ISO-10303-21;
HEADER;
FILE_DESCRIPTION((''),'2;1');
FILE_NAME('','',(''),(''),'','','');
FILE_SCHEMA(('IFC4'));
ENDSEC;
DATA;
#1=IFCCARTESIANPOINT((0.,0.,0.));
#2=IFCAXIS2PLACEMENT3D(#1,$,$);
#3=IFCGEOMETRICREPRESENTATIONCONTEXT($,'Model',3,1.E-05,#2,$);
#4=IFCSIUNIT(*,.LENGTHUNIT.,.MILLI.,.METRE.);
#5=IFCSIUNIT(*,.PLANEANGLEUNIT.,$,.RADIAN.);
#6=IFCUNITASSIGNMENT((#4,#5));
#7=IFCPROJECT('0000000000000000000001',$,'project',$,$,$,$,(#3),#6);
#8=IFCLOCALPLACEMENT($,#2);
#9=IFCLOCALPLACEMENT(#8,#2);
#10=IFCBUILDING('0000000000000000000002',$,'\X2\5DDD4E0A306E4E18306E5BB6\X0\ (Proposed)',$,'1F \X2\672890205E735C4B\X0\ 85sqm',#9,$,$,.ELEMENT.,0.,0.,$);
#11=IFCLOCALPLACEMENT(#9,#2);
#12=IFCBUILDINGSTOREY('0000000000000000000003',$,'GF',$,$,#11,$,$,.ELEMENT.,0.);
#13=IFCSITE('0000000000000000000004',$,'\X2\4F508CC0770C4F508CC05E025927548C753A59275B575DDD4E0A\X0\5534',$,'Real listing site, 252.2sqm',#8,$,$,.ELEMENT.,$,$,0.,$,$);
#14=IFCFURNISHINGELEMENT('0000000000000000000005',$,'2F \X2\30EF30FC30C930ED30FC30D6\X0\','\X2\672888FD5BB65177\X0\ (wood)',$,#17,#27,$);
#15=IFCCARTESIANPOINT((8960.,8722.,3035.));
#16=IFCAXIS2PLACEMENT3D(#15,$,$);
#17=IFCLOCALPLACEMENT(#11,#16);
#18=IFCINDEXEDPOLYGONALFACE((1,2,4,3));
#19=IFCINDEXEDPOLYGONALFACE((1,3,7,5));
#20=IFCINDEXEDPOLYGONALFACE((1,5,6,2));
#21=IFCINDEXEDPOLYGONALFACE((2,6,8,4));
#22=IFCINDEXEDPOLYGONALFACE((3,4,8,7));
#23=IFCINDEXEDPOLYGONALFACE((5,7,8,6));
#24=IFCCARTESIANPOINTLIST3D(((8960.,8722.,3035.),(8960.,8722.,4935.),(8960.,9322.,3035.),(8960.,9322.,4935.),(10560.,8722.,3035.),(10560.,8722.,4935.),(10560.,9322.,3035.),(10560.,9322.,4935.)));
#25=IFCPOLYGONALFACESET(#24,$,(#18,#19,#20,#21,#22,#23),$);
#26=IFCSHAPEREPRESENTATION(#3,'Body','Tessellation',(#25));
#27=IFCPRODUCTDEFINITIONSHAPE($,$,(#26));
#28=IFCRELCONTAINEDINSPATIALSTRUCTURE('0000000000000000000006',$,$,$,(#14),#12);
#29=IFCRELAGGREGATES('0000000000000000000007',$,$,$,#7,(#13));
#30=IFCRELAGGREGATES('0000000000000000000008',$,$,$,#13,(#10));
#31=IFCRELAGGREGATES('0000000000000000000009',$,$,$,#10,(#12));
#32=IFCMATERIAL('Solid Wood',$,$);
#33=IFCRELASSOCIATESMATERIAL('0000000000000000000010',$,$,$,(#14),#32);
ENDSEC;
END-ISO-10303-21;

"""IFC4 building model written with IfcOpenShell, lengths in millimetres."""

from ifc_helpers import new_model, si_unit, frame, frame_2d, origin, place, context, project, spatial, rectangle, extrude, material, element, save


model = new_model("IFC4")

# Units and contexts
model_context = context("Model", 3, precision=1e-05, world=origin())
ifc_project = project(units=[si_unit("LENGTHUNIT", "METRE", prefix="MILLI"), si_unit("PLANEANGLEUNIT", "RADIAN")], contexts=[model_context])

# Site, building, storey
site_placement = place(None, origin())
site = spatial("IfcSite", under=ifc_project, at=site_placement, Name="佐賀県佐賀市大和町大字川上5534", ObjectType="Real listing site, 252.2sqm", CompositionType="ELEMENT", RefElevation=0.0)
building_placement = place(site_placement, origin())
building = spatial("IfcBuilding", under=site, at=building_placement, Name="川上の丘の家 (Proposed)", ObjectType="1F 木造平屋 85sqm", CompositionType="ELEMENT", ElevationOfRefHeight=0.0, ElevationOfTerrain=0.0)
storey_placement = place(building_placement, origin())
storey = spatial("IfcBuildingStorey", under=building, at=storey_placement, Name="GF", CompositionType="ELEMENT", Elevation=0.0)

# Shared definitions
ifc_material_1 = material(Name="Solid Wood")

# Furnishing element
furnishing_1_placement = place(storey_placement, frame((8960.0, 8722.0, 3035.0)))
element("IfcFurnishingElement", 1, at=furnishing_1_placement, inside=storey, material=ifc_material_1, Name="2F ワードローブ", Description="木製家具 (wood)", context=model_context, shape_type="SweptSolid", body=[
    extrude(rectangle(XDim=1600.0, YDim=600.0, at=frame_2d((800.0, 300.0))), frame((8960.0, 8722.0, 3035.0)), (0.0, 0.0, 1.0), 1900.0),
])

save(model, "model.ifc")
